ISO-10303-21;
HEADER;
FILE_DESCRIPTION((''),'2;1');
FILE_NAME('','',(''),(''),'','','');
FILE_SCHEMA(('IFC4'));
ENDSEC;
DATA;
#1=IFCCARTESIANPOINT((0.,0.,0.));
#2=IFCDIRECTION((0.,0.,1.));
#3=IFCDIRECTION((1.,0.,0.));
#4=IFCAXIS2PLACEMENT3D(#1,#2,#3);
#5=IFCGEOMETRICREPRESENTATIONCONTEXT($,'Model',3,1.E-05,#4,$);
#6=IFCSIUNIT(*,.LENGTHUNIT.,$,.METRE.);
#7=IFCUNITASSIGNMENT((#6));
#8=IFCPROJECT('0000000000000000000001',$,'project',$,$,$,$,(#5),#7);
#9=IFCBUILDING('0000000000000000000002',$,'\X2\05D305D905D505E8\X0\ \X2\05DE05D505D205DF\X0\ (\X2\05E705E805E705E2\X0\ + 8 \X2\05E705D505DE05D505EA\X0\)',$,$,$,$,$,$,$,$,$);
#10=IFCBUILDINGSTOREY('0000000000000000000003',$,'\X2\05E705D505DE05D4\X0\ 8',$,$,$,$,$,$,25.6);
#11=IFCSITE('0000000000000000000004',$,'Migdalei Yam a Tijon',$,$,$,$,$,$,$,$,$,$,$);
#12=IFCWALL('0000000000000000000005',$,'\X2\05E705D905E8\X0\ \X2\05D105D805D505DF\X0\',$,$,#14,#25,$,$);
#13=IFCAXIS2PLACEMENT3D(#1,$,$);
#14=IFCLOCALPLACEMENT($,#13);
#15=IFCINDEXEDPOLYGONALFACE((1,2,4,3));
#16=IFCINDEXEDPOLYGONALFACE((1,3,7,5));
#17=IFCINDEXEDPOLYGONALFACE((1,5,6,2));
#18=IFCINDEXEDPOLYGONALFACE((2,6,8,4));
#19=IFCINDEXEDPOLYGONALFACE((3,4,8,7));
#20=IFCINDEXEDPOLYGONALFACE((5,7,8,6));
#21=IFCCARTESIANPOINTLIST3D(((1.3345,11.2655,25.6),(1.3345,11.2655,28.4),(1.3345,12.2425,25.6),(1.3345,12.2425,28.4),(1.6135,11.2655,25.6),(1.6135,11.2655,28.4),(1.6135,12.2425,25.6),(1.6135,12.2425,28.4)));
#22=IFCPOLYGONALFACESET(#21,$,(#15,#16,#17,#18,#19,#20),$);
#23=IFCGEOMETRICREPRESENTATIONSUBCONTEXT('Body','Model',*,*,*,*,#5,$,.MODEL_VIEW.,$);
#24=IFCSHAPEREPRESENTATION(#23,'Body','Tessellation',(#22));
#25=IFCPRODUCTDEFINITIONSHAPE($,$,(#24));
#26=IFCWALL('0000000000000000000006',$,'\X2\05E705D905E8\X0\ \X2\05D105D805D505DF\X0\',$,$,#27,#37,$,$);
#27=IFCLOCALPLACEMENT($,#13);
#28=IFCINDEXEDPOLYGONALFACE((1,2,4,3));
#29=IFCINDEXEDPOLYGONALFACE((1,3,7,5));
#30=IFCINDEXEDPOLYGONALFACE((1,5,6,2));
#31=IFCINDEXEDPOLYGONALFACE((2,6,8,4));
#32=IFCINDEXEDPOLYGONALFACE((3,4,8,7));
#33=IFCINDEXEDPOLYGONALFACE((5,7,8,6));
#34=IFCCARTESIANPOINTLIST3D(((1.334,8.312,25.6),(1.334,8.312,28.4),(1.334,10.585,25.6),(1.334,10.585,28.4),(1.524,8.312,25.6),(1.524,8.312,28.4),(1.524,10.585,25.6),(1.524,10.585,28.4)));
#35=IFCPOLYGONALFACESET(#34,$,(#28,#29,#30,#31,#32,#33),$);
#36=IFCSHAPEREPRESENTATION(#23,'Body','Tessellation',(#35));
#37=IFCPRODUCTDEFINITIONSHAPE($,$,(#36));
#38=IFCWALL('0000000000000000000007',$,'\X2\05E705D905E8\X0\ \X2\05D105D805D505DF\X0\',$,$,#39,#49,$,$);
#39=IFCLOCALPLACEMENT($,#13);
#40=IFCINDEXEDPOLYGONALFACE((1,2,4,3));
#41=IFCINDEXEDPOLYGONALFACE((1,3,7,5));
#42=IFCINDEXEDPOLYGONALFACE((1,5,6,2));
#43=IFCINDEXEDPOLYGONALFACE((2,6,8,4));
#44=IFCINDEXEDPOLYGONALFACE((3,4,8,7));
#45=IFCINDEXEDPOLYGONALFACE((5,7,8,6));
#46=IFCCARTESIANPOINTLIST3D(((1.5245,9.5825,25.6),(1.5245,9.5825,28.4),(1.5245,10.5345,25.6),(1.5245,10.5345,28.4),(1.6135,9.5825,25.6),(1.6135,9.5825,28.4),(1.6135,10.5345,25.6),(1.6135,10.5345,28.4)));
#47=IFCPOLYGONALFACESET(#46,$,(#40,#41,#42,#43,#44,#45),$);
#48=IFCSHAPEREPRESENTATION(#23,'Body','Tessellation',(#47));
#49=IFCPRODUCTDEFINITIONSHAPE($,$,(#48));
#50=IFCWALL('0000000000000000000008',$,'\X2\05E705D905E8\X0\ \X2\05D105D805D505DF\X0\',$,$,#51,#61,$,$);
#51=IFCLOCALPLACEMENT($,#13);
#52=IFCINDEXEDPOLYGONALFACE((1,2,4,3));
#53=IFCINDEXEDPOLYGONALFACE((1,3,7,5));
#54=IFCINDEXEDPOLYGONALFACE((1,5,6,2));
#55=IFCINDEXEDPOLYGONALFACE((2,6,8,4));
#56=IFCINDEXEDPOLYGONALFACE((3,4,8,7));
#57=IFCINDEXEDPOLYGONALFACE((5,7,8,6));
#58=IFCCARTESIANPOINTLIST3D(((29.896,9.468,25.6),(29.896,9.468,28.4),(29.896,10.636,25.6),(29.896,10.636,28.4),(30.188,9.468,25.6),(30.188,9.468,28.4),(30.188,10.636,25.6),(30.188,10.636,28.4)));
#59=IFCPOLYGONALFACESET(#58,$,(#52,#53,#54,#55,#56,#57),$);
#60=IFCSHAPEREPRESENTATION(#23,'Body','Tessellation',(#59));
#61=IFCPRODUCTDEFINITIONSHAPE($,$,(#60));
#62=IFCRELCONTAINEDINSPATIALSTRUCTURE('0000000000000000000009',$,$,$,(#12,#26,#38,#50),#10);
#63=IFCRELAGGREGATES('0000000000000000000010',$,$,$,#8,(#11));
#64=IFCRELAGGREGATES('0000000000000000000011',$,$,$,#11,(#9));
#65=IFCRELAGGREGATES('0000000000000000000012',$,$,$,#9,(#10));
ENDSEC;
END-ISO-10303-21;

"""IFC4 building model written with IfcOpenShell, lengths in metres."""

from ifc_helpers import new_model, si_unit, frame, origin_with_axes, context, subcontext, project, spatial, line, indexed_curve, outline, extrude, element, save


model = new_model("IFC4")

# Units and contexts
model_context = context("Model", 3, precision=1e-05, world=origin_with_axes())
body_context = subcontext(model_context, "Body", "Model", "MODEL_VIEW")
ifc_project = project(units=[si_unit("LENGTHUNIT", "METRE")], contexts=[model_context])

# Site, building, storey
site = spatial("IfcSite", under=ifc_project, Name="Migdalei Yam a Tijon")
building = spatial("IfcBuilding", under=site, Name="דיור מוגן (קרקע + 8 קומות)")
storey = spatial("IfcBuildingStorey", under=building, Name="קומה 8", Elevation=25.6)

# Walls
element("IfcWall", 1, inside=storey, Name="קיר בטון", context=body_context, shape_type="SweptSolid", body=[
    extrude(outline(indexed_curve([(0.0, 0.0), (0.279, 0.0), (0.279, 0.977), (0.0, 0.977)], segments=[line(1, 2, 3, 4, 1)])), frame((1.3345, 11.2655, 25.6), z_axis=(0.0, 0.0, 1.0), x_axis=(1.0, 0.0, 0.0)), (0.0, 0.0, 1.0), 2.8),
])
element("IfcWall", 2, inside=storey, Name="קיר בטון", context=body_context, shape_type="SweptSolid", body=[
    extrude(outline(indexed_curve([(0.0, 0.0), (0.19, 0.0), (0.19, 2.273), (0.0, 2.273)], segments=[line(1, 2, 3, 4, 1)])), frame((1.334, 8.312, 25.6), z_axis=(0.0, 0.0, 1.0), x_axis=(1.0, 0.0, 0.0)), (0.0, 0.0, 1.0), 2.8),
])
element("IfcWall", 3, inside=storey, Name="קיר בטון", context=body_context, shape_type="SweptSolid", body=[
    extrude(outline(indexed_curve([(0.0, 0.0), (0.089, 0.0), (0.089, 0.952), (0.0, 0.952)], segments=[line(1, 2, 3, 4, 1)])), frame((1.5245, 9.5825, 25.6), z_axis=(0.0, 0.0, 1.0), x_axis=(1.0, 0.0, 0.0)), (0.0, 0.0, 1.0), 2.8),
])
element("IfcWall", 4, inside=storey, Name="קיר בטון", context=body_context, shape_type="SweptSolid", body=[
    extrude(outline(indexed_curve([(0.0, 0.0), (0.292, 0.0), (0.292, 1.168), (0.0, 1.168)], segments=[line(1, 2, 3, 4, 1)])), frame((29.896, 9.468, 25.6), z_axis=(0.0, 0.0, 1.0), x_axis=(1.0, 0.0, 0.0)), (0.0, 0.0, 1.0), 2.8),
])

save(model, "model.ifc")
